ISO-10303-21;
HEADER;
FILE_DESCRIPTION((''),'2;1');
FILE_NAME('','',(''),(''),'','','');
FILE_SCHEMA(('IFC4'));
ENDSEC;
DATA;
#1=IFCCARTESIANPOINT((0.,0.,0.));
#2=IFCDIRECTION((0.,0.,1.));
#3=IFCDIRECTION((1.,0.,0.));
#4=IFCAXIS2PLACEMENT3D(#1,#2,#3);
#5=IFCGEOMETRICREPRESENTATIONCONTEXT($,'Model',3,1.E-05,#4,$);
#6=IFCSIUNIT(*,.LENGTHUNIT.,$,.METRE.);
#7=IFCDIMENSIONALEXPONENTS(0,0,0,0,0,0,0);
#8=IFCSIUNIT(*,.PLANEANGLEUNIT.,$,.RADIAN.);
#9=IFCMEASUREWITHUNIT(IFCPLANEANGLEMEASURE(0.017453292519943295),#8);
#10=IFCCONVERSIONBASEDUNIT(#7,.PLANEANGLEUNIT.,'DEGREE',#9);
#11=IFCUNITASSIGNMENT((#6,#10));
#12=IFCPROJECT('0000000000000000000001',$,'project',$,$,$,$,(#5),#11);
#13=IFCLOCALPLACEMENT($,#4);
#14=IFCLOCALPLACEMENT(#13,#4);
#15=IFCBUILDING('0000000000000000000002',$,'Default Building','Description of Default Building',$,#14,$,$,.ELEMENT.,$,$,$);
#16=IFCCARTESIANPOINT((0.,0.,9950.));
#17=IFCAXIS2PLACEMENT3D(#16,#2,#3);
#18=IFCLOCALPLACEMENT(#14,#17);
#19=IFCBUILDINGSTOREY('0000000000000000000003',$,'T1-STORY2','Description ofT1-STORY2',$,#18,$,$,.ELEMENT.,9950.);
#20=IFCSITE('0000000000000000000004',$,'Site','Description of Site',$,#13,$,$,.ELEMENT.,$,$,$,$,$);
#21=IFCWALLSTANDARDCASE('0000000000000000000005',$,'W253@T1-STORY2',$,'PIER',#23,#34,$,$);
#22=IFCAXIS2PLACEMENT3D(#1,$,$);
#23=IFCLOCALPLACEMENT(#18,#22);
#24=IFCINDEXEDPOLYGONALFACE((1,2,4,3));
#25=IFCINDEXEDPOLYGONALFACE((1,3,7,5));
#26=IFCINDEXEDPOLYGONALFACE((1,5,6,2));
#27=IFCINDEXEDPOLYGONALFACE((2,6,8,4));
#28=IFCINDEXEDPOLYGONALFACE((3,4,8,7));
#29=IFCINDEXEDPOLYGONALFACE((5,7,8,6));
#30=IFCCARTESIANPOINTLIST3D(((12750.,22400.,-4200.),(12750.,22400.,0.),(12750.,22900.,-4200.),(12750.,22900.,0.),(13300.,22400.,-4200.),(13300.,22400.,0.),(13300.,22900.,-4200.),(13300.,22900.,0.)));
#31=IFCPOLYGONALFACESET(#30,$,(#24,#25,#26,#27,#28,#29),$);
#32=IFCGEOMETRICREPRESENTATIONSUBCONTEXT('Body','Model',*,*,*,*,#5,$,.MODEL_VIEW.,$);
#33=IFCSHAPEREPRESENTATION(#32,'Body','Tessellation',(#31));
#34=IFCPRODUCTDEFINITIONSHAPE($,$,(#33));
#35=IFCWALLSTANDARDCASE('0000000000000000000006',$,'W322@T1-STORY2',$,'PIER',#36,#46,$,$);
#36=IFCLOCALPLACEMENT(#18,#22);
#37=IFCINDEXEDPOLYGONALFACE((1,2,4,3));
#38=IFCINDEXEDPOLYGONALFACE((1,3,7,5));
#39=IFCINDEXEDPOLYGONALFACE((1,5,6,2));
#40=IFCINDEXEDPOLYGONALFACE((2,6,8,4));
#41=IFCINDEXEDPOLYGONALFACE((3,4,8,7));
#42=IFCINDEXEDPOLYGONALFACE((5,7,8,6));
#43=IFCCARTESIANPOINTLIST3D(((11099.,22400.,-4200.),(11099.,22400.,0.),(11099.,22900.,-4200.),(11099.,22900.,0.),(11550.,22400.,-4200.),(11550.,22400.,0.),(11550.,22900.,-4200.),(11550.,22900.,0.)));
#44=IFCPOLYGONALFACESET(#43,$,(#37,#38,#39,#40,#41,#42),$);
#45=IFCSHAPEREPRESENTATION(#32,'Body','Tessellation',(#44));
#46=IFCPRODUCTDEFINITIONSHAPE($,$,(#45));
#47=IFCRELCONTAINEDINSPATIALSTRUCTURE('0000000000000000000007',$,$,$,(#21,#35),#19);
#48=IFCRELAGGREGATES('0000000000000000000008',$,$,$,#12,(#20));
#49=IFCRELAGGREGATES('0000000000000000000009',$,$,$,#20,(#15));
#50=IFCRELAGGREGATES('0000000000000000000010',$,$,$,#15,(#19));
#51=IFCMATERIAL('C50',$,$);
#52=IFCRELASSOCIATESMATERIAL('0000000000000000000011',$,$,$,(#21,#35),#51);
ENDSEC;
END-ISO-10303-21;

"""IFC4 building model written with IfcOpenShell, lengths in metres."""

from ifc_helpers import new_model, entity, si_unit, converted_unit, frame, origin_with_axes, place, context, subcontext, project, spatial, indexed_curve, outline, extrude, material, element, save


model = new_model("IFC4")

# Units and contexts
model_context = context("Model", 3, precision=1e-05, world=origin_with_axes())
body_context = subcontext(model_context, "Body", "Model", "MODEL_VIEW")
ifc_project = project(units=[si_unit("LENGTHUNIT", "METRE"), converted_unit("PLANEANGLEUNIT", "DEGREE", entity("IfcPlaneAngleMeasure", 0.017453292519943295), si_unit("PLANEANGLEUNIT", "RADIAN"), dimensions=[0, 0, 0, 0, 0, 0, 0])], contexts=[model_context])

# Site, building, storey
site_placement = place(None, origin_with_axes())
site = spatial("IfcSite", under=ifc_project, at=site_placement, Name="Site", Description="Description of Site", CompositionType="ELEMENT")
building_placement = place(site_placement, origin_with_axes())
building = spatial("IfcBuilding", under=site, at=building_placement, Name="Default Building", Description="Description of Default Building", CompositionType="ELEMENT")
storey_placement = place(building_placement, frame((0.0, 0.0, 9950.0), z_axis=(0.0, 0.0, 1.0), x_axis=(1.0, 0.0, 0.0)))
storey = spatial("IfcBuildingStorey", under=building, at=storey_placement, Name="T1-STORY2", Description="Description ofT1-STORY2", CompositionType="ELEMENT", Elevation=9950.0)

# Shared definitions
ifc_material_1 = material(Name="C50")

# Walls
wall_1_placement = place(storey_placement, frame((12750.0, 22650.0, -4200.0), z_axis=(0.0, 0.0, 1.0), x_axis=(1.0, 0.0, 0.0)))
element("IfcWallStandardCase", 1, at=wall_1_placement, inside=storey, material=ifc_material_1, Name="W253@T1-STORY2", ObjectType="PIER", context=body_context, shape_type="SweptSolid", body=[
    extrude(outline(indexed_curve([(0.0, -250.0), (0.0, 250.0), (550.0, 250.0), (550.0, -250.0), (0.0, -250.0)], self_intersect=False)), origin_with_axes(), (0.0, 0.0, 1.0), 4200.0),
])
wall_2_placement = place(storey_placement, frame((11099.0, 22650.0, -4200.0), z_axis=(0.0, 0.0, 1.0), x_axis=(1.0, 0.0, 0.0)))
element("IfcWallStandardCase", 2, at=wall_2_placement, inside=storey, material=ifc_material_1, Name="W322@T1-STORY2", ObjectType="PIER", context=body_context, shape_type="SweptSolid", body=[
    extrude(outline(indexed_curve([(0.0, -250.0), (0.0, 250.0), (451.0, 250.0), (451.0, -250.0), (0.0, -250.0)], self_intersect=False)), origin_with_axes(), (0.0, 0.0, 1.0), 4200.0),
])

save(model, "model.ifc")
